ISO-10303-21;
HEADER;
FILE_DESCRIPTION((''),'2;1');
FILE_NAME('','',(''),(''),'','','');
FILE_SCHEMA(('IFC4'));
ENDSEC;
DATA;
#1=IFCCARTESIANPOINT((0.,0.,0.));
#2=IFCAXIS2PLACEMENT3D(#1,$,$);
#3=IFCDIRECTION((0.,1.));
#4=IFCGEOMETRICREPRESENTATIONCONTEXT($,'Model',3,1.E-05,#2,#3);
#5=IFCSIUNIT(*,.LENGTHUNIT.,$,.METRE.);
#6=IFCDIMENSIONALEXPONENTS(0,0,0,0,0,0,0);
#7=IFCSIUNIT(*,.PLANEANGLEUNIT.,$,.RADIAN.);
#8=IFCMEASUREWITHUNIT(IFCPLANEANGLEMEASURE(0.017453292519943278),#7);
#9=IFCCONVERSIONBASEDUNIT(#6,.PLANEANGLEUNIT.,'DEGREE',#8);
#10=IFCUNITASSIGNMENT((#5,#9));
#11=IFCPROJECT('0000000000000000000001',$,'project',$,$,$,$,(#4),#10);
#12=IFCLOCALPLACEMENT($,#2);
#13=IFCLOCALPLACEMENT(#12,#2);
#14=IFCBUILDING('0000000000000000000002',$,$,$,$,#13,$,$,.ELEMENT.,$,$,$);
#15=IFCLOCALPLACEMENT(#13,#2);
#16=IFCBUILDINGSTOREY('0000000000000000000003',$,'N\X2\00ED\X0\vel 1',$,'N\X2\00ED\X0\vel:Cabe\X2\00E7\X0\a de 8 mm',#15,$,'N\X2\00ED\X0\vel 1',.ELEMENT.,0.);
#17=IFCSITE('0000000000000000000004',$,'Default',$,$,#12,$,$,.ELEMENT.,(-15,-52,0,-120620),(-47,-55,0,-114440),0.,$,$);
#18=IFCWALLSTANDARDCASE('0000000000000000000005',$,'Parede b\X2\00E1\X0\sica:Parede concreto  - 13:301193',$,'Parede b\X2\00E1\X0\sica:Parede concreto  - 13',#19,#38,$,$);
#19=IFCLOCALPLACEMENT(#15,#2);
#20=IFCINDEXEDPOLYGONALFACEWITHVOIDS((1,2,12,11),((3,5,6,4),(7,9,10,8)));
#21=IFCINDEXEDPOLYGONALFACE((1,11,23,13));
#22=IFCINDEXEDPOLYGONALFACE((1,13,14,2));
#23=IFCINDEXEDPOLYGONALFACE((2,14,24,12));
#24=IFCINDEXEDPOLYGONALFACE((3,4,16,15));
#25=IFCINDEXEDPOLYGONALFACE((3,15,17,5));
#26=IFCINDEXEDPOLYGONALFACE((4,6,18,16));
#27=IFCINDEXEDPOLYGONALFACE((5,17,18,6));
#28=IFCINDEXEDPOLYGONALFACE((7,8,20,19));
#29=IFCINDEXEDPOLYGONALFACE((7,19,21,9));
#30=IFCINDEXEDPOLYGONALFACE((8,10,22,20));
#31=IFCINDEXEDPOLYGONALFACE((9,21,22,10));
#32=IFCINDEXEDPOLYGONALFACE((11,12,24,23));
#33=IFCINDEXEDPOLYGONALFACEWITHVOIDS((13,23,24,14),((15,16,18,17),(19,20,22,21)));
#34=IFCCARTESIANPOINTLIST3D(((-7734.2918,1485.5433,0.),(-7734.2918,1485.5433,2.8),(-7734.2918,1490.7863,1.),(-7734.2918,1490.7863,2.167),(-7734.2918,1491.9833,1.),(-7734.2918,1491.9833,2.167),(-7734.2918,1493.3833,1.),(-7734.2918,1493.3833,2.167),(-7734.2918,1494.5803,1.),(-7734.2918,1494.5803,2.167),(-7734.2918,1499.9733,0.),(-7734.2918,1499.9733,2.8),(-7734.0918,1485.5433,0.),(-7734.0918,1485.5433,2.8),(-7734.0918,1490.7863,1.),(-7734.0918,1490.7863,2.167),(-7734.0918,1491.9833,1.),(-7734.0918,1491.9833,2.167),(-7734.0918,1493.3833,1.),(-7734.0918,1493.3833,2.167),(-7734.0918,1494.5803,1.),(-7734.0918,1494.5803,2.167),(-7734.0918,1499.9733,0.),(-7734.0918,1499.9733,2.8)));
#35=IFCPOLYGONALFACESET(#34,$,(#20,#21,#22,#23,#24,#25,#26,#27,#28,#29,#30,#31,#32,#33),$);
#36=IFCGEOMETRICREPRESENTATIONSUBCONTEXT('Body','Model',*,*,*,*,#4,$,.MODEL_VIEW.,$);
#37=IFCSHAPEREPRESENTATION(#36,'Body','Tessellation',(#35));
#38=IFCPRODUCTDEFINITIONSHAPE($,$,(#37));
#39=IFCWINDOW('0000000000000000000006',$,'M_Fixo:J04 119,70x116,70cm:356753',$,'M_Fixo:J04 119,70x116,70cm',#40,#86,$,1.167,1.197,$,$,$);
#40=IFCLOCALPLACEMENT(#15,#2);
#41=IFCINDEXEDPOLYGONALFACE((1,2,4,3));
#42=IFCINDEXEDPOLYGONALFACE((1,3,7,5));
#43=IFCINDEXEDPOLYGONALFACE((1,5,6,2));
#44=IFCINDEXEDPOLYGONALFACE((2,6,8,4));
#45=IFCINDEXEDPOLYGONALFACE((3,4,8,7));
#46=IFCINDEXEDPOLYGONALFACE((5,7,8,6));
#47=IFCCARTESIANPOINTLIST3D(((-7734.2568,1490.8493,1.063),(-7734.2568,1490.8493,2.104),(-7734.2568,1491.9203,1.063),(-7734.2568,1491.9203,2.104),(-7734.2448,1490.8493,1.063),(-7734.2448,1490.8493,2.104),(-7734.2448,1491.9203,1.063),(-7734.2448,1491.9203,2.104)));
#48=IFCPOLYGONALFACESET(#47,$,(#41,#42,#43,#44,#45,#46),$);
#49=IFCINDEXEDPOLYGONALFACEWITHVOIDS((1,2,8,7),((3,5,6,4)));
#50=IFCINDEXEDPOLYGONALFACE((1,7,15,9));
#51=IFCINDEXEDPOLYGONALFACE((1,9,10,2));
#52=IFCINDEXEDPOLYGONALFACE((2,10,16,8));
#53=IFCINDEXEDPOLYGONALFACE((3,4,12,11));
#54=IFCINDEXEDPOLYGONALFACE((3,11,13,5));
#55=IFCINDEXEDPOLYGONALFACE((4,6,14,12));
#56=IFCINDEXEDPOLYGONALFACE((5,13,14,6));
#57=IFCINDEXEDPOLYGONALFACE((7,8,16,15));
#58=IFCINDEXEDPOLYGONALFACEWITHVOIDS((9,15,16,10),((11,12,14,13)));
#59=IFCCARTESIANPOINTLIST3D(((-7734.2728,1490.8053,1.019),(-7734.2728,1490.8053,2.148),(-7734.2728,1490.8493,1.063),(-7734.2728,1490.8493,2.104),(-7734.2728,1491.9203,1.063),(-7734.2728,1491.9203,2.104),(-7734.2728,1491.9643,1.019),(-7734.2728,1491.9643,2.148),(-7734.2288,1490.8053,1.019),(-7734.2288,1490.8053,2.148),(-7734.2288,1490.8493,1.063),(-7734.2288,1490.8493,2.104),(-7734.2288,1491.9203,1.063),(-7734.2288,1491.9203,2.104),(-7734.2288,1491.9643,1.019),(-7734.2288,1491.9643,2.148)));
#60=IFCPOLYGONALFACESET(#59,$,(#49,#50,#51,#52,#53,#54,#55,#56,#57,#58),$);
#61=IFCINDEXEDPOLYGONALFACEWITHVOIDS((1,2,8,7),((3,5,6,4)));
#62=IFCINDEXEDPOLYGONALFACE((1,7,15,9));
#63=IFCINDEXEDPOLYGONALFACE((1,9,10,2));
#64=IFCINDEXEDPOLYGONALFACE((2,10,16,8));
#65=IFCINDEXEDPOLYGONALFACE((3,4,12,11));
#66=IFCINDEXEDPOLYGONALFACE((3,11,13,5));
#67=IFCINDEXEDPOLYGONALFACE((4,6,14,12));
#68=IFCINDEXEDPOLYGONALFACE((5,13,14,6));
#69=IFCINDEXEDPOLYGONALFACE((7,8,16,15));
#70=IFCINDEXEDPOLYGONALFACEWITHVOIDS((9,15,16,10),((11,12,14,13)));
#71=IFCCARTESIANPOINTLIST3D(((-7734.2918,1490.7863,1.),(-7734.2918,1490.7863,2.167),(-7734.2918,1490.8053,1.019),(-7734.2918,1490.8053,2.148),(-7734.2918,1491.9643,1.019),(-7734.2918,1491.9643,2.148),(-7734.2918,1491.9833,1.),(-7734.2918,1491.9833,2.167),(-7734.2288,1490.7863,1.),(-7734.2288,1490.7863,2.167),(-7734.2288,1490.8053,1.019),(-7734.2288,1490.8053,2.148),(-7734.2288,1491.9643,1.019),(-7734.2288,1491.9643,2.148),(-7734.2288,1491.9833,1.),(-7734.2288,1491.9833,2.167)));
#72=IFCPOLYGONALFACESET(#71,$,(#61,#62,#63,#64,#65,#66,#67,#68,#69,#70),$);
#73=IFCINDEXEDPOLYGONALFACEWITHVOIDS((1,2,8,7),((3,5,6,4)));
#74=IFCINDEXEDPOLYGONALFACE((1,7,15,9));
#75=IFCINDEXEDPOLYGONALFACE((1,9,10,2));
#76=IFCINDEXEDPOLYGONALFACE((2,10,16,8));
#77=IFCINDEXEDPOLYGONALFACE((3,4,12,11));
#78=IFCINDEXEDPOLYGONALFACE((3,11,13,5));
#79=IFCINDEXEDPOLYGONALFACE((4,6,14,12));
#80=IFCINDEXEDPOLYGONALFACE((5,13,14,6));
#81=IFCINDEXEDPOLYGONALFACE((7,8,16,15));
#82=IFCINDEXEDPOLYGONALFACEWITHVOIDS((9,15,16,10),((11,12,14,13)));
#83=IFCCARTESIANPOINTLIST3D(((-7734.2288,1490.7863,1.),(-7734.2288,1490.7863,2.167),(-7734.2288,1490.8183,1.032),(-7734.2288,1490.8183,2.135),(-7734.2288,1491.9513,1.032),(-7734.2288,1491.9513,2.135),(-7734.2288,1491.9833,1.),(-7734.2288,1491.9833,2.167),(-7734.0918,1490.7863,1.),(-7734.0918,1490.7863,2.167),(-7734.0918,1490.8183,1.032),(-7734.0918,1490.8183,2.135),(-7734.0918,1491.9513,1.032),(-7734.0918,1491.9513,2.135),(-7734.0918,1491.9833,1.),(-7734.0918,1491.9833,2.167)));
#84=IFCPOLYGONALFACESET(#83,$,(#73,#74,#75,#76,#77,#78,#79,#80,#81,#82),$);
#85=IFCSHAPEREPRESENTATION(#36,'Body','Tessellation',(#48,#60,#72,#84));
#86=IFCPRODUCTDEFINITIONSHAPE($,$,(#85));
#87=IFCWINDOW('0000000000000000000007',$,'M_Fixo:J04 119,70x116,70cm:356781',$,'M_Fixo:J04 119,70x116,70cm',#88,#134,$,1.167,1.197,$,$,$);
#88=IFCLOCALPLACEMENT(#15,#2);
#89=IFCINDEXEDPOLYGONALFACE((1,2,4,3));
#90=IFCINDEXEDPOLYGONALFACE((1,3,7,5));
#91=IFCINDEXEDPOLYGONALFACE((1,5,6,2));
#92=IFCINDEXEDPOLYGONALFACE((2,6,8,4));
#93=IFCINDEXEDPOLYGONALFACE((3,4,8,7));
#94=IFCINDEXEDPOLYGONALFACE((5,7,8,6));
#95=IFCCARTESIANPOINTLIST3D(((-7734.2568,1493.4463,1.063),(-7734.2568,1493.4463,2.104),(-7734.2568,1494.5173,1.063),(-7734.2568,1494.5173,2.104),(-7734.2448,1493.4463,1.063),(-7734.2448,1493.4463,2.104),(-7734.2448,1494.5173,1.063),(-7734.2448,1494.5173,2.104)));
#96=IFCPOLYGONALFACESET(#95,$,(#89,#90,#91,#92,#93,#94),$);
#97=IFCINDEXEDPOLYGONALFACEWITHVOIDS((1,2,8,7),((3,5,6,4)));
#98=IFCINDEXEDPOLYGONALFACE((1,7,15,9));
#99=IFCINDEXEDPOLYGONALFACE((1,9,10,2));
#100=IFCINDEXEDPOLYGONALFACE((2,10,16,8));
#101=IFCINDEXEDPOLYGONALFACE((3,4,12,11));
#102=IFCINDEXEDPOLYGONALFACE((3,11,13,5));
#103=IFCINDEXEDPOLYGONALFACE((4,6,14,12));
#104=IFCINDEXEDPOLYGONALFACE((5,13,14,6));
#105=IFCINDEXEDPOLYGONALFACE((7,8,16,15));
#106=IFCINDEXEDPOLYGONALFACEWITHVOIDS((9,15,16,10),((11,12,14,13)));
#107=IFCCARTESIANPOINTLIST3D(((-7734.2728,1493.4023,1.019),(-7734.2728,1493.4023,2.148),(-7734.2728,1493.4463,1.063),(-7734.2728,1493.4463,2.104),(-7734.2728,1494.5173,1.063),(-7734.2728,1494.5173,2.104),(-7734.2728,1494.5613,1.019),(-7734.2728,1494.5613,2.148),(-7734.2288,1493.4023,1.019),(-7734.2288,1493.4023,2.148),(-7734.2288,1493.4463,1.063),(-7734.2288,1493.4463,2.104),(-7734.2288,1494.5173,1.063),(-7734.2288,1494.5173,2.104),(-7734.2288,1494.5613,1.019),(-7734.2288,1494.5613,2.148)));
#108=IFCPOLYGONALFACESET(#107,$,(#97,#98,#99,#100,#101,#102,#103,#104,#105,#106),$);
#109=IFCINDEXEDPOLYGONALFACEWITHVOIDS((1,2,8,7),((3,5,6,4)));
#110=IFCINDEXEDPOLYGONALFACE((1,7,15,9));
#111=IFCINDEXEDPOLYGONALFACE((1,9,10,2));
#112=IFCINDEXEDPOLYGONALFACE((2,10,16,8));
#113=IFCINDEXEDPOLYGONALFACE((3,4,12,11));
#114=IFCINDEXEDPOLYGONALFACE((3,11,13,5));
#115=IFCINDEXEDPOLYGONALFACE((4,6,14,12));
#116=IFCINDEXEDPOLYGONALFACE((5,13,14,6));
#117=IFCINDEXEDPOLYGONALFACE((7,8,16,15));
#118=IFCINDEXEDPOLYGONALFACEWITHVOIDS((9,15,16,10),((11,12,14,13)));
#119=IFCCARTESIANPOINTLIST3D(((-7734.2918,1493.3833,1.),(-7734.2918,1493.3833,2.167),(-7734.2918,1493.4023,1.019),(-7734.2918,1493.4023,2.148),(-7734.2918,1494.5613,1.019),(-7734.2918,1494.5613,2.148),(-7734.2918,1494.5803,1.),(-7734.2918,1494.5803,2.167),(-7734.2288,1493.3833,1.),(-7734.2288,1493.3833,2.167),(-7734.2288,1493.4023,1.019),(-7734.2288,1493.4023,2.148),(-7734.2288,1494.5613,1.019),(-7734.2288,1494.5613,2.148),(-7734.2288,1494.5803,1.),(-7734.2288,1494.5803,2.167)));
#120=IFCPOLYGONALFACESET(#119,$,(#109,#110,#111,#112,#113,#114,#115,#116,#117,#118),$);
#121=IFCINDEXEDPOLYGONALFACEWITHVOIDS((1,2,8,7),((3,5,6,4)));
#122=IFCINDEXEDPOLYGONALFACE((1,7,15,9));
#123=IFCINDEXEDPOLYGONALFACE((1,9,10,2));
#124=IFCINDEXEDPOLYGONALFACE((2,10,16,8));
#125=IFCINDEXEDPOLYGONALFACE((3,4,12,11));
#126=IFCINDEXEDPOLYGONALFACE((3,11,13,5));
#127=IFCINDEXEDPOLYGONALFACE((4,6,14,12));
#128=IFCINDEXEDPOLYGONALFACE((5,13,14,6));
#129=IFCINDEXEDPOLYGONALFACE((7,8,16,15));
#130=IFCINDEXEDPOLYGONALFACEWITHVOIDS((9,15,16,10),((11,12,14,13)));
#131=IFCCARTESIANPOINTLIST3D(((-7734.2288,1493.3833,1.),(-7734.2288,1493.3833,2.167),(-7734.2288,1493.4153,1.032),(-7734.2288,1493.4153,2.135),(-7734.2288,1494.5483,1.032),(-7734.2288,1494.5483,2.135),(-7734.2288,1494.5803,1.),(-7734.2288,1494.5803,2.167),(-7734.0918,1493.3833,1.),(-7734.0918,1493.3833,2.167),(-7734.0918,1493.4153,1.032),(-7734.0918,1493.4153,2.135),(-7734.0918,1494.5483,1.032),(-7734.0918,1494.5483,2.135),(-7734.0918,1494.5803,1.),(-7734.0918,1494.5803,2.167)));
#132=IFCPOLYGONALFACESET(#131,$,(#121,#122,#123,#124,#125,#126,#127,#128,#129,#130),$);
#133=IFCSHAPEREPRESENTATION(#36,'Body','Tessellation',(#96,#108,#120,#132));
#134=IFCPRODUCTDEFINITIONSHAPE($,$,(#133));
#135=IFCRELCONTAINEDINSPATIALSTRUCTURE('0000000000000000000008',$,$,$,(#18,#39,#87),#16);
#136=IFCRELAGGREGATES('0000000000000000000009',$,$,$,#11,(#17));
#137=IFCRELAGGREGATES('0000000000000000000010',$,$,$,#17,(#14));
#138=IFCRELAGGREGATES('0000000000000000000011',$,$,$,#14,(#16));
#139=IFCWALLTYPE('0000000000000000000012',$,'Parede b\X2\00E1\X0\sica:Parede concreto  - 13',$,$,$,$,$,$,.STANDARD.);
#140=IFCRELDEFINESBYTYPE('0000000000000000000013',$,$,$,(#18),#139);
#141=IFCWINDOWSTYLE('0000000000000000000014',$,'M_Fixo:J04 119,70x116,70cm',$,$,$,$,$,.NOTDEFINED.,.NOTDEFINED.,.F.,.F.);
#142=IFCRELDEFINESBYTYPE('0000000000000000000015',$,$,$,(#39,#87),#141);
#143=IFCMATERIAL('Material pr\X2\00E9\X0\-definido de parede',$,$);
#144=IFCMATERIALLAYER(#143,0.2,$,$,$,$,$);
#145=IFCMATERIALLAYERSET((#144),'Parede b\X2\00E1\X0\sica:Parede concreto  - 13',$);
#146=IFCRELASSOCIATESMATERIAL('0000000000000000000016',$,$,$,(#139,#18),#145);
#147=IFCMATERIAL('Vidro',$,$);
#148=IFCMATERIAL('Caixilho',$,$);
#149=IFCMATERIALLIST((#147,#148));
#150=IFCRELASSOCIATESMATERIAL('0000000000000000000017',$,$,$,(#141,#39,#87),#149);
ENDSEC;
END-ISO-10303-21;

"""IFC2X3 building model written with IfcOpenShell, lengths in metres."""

from ifc_helpers import new_model, entity, si_unit, converted_unit, direction, frame, frame_2d, origin, place, context, subcontext, project, spatial, polyline, rectangle, outline, extrude, source, transform, mapped, material, material_list, layer, layer_set, layer_usage, type_object, type_shapes, element, fill, save


model = new_model("IFC2X3")

# Units and contexts
model_context = context("Model", 3, precision=1e-05, world=origin(), true_north=direction((0.0, 1.0)))
body_context = subcontext(model_context, "Body", "Model", "MODEL_VIEW")
ifc_project = project(units=[si_unit("LENGTHUNIT", "METRE"), converted_unit("PLANEANGLEUNIT", "DEGREE", entity("IfcPlaneAngleMeasure", 0.017453292519943278), si_unit("PLANEANGLEUNIT", "RADIAN"), dimensions=[0, 0, 0, 0, 0, 0, 0])], contexts=[model_context])

# Site, building, storey
site_placement = place(None, origin())
site = spatial("IfcSite", under=ifc_project, at=site_placement, Name="Default", CompositionType="ELEMENT", RefLatitude=(-15, -52, 0, -120620), RefLongitude=(-47, -55, 0, -114440), RefElevation=0.0)
building_placement = place(site_placement, origin())
building = spatial("IfcBuilding", under=site, at=building_placement, CompositionType="ELEMENT")
storey_placement = place(building_placement, origin())
storey = spatial("IfcBuildingStorey", under=building, at=storey_placement, Name="Nível 1", ObjectType="Nível:Cabeça de 8 mm", LongName="Nível 1", CompositionType="ELEMENT", Elevation=0.0)

# Wall, openings, windows
ifc_material_1 = material(Name="Material pré-definido de parede")
ifc_layer = layer(ifc_material_1, 0.2)
ifc_layer_set = layer_set([ifc_layer], Name="Parede básica:Parede concreto  - 13")
ifc_layer_usage_1 = layer_usage(ifc_layer_set, "AXIS2", "NEGATIVE", 0.1)
wall_type = type_object("IfcWallType", Name="Parede básica:Parede concreto  - 13", PredefinedType="STANDARD", material=ifc_layer_set)
wall_1_placement = place(storey_placement, frame((-7734.1918, 1499.9733, 0.0), z_axis=(0.0, 0.0, 1.0), x_axis=(0.0, -1.0, 0.0)))
wall_1 = element("IfcWallStandardCase", 1, at=wall_1_placement, inside=storey, type_object=wall_type, material=ifc_layer_usage_1, Name="Parede básica:Parede concreto  - 13:301193", ObjectType="Parede básica:Parede concreto  - 13", context=body_context, shape_type="SweptSolid", body=[
    extrude(rectangle(XDim=14.43, YDim=0.2, at=frame_2d((7.215, 0.0), x_axis=(-1.0, 0.0))), origin(), (0.0, 0.0, 1.0), 2.8),
])
opening_1_placement = place(wall_1_placement, frame((9.187, 0.1, 1.0)))
opening_1 = element("IfcOpeningElement", 2, at=opening_1_placement, cuts=wall_1, ObjectType="Opening", context=body_context, shape_type="SweptSolid", body=[
    extrude(rectangle(XDim=1.167, YDim=1.197, at=frame_2d((0.5835, 0.5985), x_axis=(1.0, 0.0))), frame((0.0, 0.0, 0.0), z_axis=(0.0, -1.0, 0.0), x_axis=(0.0, 0.0, 1.0)), (0.0, 0.0, 1.0), 0.2),
])
opening_2_placement = place(wall_1_placement, frame((6.59, 0.1, 1.0)))
opening_2 = element("IfcOpeningElement", 3, at=opening_2_placement, cuts=wall_1, ObjectType="Opening", context=body_context, shape_type="SweptSolid", body=[
    extrude(rectangle(XDim=1.167, YDim=1.197, at=frame_2d((0.5835, 0.5985), x_axis=(1.0, 0.0))), frame((0.0, 0.0, 0.0), z_axis=(0.0, -1.0, 0.0), x_axis=(0.0, 0.0, 1.0)), (0.0, 0.0, 1.0), 0.2),
])
ifc_material_2 = material(Name="Vidro")
ifc_material_3 = material(Name="Caixilho")
ifc_material_list = material_list([ifc_material_2, ifc_material_3])
window_style_1 = type_object("IfcWindowStyle", Name="M_Fixo:J04 119,70x116,70cm", ConstructionType="NOTDEFINED", OperationType="NOTDEFINED", ParameterTakesPrecedence=False, Sizeable=False, material=ifc_material_list)
shared_shape_1 = source(origin(), body_context, "Body", "SweptSolid", [
    extrude(rectangle(XDim=0.012, YDim=1.071, at=frame_2d((0.0, 0.0), x_axis=(1.0, 0.0))), frame((0.5985, 0.159, 0.063), z_axis=(0.0, 0.0, 1.0), x_axis=(0.0, -1.0, 0.0)), (0.0, 0.0, 1.0), 1.041),
    extrude(outline(polyline([(-0.5795, -0.5645), (0.5795, -0.5645), (0.5795, 0.5645), (-0.5795, 0.5645), (-0.5795, -0.5645)]), holes=[polyline([(-0.5355, -0.5205), (-0.5355, 0.5205), (0.5355, 0.5205), (0.5355, -0.5205), (-0.5355, -0.5205)])]), frame((0.5985, 0.137, 0.5835), z_axis=(0.0, 1.0, 0.0), x_axis=(1.0, 0.0, 0.0)), (0.0, 0.0, 1.0), 0.044),
    extrude(outline(polyline([(-0.5985, -0.5835), (0.5985, -0.5835), (0.5985, 0.5835), (-0.5985, 0.5835), (-0.5985, -0.5835)]), holes=[polyline([(-0.5795, -0.5645), (-0.5795, 0.5645), (0.5795, 0.5645), (0.5795, -0.5645), (-0.5795, -0.5645)])]), frame((0.5985, 0.137, 0.5835), z_axis=(0.0, 1.0, 0.0), x_axis=(1.0, 0.0, 0.0)), (0.0, 0.0, 1.0), 0.063),
    extrude(outline(polyline([(-0.5985, -0.5835), (0.5985, -0.5835), (0.5985, 0.5835), (-0.5985, 0.5835), (-0.5985, -0.5835)]), holes=[polyline([(-0.5665, -0.5515), (-0.5665, 0.5515), (0.5665, 0.5515), (0.5665, -0.5515), (-0.5665, -0.5515)])]), frame((0.5985, 0.0, 0.5835), z_axis=(0.0, 1.0, 0.0), x_axis=(1.0, 0.0, 0.0)), (0.0, 0.0, 1.0), 0.137),
])
type_shapes(window_style_1, [shared_shape_1])
window_1_placement = place(opening_1_placement, frame((0.0, 0.0, 0.0), z_axis=(0.0, 0.0, 1.0), x_axis=(-1.0, 0.0, 0.0)))
window_1 = element("IfcWindow", 4, at=window_1_placement, inside=storey, type_object=window_style_1, material=ifc_material_list, Name="M_Fixo:J04 119,70x116,70cm:356753", ObjectType="M_Fixo:J04 119,70x116,70cm", OverallHeight=1.167, OverallWidth=1.197, context=body_context, shape_type="MappedRepresentation", body=[
    mapped(shared_shape_1, transform((0.0, 0.0, 0.0), scale=1.0)),
])
fill(opening_1, window_1)
window_2_placement = place(opening_2_placement, frame((0.0, 0.0, 0.0), z_axis=(0.0, 0.0, 1.0), x_axis=(-1.0, 0.0, 0.0)))
window_2 = element("IfcWindow", 5, at=window_2_placement, inside=storey, type_object=window_style_1, material=ifc_material_list, Name="M_Fixo:J04 119,70x116,70cm:356781", ObjectType="M_Fixo:J04 119,70x116,70cm", OverallHeight=1.167, OverallWidth=1.197, context=body_context, shape_type="MappedRepresentation", body=[
    mapped(shared_shape_1, transform((0.0, 0.0, 0.0), scale=1.0)),
])
fill(opening_2, window_2)

save(model, "model.ifc")
